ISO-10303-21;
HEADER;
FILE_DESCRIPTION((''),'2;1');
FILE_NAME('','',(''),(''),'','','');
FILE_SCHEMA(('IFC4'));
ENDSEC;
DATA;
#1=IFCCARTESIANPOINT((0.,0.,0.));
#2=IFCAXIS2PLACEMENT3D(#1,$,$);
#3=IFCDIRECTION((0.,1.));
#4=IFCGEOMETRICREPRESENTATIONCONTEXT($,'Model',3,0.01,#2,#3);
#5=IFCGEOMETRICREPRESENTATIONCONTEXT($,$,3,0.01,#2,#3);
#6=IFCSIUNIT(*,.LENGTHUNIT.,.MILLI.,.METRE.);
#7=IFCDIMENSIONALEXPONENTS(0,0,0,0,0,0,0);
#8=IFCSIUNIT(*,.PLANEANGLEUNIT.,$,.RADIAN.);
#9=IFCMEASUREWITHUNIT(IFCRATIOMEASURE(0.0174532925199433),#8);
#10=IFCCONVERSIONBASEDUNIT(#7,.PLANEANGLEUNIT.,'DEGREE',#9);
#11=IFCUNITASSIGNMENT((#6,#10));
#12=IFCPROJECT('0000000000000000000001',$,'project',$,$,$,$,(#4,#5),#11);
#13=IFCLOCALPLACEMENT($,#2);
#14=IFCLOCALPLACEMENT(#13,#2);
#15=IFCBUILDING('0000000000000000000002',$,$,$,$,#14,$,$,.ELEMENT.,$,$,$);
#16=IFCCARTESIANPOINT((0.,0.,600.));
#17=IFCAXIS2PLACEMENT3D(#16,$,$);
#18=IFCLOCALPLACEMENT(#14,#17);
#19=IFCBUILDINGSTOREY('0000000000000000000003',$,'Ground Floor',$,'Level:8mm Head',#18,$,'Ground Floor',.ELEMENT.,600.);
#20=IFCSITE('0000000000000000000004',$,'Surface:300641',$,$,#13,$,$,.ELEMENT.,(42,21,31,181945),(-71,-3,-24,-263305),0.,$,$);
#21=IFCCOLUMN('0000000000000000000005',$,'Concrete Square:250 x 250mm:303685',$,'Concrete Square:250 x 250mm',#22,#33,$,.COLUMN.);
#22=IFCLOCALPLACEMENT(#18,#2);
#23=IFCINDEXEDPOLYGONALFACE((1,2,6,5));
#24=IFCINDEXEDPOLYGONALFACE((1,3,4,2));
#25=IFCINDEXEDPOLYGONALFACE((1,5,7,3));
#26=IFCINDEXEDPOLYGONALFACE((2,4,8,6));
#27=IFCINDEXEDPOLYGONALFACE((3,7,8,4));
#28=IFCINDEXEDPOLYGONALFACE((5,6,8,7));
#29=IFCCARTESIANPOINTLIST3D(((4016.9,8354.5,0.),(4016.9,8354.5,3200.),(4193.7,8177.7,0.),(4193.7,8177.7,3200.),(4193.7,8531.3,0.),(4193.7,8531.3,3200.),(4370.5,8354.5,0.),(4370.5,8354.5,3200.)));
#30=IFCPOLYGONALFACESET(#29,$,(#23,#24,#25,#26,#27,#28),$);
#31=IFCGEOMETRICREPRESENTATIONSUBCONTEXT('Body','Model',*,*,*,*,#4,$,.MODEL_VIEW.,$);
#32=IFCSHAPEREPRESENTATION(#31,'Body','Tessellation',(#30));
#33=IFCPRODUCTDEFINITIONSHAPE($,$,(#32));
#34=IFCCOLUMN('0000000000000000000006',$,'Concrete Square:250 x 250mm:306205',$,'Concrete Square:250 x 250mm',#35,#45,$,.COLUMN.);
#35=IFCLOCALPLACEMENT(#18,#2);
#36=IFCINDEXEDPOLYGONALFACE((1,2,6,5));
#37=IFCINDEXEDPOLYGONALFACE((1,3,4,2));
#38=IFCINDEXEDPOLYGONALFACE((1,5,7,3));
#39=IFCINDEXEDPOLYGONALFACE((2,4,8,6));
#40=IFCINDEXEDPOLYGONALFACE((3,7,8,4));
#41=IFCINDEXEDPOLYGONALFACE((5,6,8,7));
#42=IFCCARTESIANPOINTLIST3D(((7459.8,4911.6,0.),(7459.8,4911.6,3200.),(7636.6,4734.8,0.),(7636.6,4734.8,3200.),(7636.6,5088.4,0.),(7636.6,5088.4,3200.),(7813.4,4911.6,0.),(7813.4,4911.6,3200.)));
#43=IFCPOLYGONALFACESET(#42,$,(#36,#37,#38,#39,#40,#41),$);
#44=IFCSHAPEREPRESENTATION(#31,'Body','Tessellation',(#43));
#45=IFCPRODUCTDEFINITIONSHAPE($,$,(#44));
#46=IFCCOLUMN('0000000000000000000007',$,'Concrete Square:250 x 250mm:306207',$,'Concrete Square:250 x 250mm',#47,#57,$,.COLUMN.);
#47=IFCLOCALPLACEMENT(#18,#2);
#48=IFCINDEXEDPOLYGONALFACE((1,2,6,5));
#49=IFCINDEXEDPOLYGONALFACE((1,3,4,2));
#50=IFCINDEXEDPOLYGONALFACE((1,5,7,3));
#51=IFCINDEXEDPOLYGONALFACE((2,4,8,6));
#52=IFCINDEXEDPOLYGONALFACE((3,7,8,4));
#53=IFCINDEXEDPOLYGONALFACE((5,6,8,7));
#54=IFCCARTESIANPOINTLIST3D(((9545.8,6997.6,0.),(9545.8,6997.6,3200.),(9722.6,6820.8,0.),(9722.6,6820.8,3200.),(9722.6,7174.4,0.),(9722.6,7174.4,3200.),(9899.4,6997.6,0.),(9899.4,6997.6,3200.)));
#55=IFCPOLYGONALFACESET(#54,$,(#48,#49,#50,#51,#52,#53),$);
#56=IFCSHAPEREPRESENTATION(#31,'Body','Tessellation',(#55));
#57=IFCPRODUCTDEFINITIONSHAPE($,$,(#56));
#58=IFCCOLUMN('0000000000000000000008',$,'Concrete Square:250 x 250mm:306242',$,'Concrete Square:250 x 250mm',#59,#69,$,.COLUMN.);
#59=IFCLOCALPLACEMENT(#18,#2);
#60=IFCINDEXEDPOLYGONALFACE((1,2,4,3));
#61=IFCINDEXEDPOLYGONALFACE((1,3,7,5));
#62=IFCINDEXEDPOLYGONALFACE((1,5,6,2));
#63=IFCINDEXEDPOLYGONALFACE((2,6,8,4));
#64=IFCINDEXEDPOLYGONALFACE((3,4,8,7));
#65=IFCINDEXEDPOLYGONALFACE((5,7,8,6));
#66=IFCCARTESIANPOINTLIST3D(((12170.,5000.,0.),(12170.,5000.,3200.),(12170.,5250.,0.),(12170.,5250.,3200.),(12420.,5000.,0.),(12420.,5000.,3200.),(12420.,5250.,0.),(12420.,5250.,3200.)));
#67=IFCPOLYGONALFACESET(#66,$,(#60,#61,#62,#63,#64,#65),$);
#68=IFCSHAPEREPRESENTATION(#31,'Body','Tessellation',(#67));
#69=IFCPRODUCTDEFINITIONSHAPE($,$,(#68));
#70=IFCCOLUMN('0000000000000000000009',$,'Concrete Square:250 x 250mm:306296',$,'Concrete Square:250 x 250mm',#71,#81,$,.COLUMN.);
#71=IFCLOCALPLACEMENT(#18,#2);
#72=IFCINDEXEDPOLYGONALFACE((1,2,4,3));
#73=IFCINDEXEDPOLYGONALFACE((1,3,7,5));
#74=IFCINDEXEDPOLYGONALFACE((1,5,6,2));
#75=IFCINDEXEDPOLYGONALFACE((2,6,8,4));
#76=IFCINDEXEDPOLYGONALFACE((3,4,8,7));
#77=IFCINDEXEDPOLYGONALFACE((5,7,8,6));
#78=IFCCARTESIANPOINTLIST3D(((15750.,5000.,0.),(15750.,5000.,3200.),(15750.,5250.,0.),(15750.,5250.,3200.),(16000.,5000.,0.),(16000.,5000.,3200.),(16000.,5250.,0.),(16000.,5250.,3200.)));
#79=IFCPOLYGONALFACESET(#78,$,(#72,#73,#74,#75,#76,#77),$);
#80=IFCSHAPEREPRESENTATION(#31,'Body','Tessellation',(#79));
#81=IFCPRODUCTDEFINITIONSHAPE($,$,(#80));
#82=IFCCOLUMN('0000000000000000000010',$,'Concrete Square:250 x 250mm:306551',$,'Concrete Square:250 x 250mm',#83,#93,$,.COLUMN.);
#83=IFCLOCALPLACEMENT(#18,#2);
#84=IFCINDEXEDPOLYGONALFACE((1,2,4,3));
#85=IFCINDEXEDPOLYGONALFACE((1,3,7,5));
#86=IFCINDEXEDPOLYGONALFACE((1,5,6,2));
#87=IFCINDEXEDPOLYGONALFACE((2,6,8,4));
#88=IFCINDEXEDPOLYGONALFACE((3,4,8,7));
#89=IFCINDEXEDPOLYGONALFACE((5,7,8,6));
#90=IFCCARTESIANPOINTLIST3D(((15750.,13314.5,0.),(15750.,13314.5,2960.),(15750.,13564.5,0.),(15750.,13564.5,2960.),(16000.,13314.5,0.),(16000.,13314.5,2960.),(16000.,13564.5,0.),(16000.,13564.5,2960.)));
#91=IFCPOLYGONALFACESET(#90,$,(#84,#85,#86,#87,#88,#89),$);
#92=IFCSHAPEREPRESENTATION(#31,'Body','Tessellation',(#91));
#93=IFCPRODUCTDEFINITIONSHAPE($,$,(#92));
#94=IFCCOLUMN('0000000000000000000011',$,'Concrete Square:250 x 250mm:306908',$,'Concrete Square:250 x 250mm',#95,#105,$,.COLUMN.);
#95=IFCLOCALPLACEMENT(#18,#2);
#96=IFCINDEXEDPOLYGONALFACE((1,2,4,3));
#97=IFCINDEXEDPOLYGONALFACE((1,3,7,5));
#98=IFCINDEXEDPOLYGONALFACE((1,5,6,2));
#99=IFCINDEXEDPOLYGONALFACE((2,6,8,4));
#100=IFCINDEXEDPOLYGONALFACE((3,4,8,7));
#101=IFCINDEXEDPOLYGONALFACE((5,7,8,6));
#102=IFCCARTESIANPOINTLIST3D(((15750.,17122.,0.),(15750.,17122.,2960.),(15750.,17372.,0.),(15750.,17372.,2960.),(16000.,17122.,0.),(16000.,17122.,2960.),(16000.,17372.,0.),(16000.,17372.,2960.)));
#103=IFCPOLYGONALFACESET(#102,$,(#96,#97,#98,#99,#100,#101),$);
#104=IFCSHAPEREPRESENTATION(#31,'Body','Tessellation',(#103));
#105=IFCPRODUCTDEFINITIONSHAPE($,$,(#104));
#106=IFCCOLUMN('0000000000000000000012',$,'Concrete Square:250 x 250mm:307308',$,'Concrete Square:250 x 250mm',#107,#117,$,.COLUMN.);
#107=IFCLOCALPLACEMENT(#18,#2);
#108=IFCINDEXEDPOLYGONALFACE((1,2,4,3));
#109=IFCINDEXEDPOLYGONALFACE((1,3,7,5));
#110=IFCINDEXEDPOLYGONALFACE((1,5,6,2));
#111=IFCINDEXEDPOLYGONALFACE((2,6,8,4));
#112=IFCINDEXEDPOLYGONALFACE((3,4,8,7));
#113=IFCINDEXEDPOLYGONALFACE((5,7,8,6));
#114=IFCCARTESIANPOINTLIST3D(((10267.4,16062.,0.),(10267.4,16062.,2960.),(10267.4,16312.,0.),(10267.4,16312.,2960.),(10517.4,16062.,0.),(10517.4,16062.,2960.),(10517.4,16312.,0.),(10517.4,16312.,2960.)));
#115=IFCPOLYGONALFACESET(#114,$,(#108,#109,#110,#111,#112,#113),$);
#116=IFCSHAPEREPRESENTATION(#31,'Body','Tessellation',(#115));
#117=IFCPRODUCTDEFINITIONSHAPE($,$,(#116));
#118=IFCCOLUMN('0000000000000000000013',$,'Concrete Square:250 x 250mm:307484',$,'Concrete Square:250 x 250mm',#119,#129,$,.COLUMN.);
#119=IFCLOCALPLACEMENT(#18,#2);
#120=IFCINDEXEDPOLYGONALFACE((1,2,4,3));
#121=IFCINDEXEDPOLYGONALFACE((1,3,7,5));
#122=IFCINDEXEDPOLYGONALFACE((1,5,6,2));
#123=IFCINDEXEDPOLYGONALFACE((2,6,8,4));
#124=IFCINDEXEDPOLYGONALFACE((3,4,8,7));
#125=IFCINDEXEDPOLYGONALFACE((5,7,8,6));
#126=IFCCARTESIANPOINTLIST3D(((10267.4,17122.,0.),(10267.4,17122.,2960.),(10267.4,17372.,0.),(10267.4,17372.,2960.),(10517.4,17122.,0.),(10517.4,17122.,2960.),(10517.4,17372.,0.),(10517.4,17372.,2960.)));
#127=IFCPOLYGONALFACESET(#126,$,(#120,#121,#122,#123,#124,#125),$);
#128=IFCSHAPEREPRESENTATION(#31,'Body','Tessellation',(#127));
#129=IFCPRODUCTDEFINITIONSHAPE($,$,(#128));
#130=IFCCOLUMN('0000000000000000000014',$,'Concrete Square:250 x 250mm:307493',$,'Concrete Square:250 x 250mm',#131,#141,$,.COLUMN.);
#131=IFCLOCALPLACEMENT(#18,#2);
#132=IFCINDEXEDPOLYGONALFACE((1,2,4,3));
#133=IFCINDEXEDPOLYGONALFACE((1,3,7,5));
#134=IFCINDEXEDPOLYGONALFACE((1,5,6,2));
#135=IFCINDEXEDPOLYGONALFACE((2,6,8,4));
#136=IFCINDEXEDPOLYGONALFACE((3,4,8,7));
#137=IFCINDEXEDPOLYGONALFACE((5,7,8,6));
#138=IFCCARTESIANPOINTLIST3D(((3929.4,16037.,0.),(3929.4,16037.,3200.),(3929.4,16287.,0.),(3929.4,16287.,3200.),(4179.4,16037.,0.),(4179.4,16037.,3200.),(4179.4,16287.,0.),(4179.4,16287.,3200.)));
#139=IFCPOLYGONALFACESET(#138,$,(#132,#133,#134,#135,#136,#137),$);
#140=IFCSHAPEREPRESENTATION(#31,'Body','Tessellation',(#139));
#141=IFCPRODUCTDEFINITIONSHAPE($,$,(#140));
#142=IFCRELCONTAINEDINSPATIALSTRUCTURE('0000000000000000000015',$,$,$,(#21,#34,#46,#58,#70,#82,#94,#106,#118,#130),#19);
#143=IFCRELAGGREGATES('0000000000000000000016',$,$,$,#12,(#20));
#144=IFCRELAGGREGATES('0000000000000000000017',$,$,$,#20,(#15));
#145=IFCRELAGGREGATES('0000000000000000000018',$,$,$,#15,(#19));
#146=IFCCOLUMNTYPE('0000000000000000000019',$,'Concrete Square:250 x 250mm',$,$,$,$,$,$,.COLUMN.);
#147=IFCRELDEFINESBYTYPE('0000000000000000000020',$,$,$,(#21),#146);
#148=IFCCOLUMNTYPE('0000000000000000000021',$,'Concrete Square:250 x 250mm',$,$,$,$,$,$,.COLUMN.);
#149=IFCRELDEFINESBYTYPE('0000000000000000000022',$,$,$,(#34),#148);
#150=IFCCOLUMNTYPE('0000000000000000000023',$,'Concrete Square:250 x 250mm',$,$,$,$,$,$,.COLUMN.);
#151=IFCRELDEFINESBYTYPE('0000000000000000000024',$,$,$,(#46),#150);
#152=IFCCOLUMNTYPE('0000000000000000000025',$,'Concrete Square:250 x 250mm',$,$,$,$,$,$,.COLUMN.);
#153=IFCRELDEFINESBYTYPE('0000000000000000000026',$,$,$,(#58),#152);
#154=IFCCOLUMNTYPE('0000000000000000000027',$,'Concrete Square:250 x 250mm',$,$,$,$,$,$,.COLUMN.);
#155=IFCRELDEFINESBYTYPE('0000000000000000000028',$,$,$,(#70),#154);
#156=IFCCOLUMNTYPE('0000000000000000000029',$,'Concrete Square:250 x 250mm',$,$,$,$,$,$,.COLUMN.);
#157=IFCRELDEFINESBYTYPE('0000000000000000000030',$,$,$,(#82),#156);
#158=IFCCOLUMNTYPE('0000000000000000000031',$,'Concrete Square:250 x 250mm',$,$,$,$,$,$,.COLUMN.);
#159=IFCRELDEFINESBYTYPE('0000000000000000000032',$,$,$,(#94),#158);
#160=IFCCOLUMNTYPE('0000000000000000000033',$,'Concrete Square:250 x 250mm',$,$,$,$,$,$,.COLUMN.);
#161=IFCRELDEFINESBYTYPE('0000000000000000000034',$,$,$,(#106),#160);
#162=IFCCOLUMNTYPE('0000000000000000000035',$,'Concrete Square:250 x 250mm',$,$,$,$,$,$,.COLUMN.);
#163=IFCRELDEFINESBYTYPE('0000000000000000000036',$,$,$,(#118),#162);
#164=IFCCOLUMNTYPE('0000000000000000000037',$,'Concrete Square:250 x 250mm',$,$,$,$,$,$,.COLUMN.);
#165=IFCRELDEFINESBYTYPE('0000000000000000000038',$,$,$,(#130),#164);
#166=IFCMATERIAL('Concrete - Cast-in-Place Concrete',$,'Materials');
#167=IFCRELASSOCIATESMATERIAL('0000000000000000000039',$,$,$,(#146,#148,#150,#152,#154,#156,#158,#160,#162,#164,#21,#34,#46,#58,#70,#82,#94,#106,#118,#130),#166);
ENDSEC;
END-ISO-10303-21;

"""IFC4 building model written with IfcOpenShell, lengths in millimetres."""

from ifc_helpers import new_model, entity, si_unit, converted_unit, direction, frame, frame_2d, origin, origin_2d_with_axis, place, context, subcontext, project, spatial, rectangle, extrude, source, transform, mapped, material, material_profile, profile_set, profile_usage, type_object, type_shapes, element, save


model = new_model("IFC4")

# Units and contexts
model_context = context("Model", 3, precision=0.01, world=origin(), true_north=direction((0.0, 1.0)))
context_of_model = context(None, 3, precision=0.01, world=origin(), true_north=direction((0.0, 1.0)))
body_context = subcontext(model_context, "Body", "Model", "MODEL_VIEW")
ifc_project = project(units=[si_unit("LENGTHUNIT", "METRE", prefix="MILLI"), converted_unit("PLANEANGLEUNIT", "DEGREE", entity("IfcRatioMeasure", 0.0174532925199433), si_unit("PLANEANGLEUNIT", "RADIAN"), dimensions=[0, 0, 0, 0, 0, 0, 0])], contexts=[model_context, context_of_model])

# Site, building, storey
site_placement = place(None, origin())
site = spatial("IfcSite", under=ifc_project, at=site_placement, Name="Surface:300641", CompositionType="ELEMENT", RefLatitude=(42, 21, 31, 181945), RefLongitude=(-71, -3, -24, -263305), RefElevation=0.0)
building_placement = place(site_placement, origin())
building = spatial("IfcBuilding", under=site, at=building_placement, CompositionType="ELEMENT")
storey_placement = place(building_placement, frame((0.0, 0.0, 600.0)))
storey = spatial("IfcBuildingStorey", under=building, at=storey_placement, Name="Ground Floor", ObjectType="Level:8mm Head", LongName="Ground Floor", CompositionType="ELEMENT", Elevation=600.0)

# Columns
ifc_material_1 = material(Name="Concrete - Cast-in-Place Concrete", Category="Materials")
ifc_material_profile_1 = material_profile(ifc_material_1, rectangle(XDim=250.0, YDim=250.0, at=frame_2d((0.0, 0.0), x_axis=(1.0, 0.0))), Name="250 x 250mm")
ifc_profile_set_1 = profile_set([ifc_material_profile_1], Name="250 x 250mm")
ifc_profile_usage_1 = profile_usage(ifc_profile_set_1)
column_type_1 = type_object("IfcColumnType", Name="Concrete Square:250 x 250mm", PredefinedType="COLUMN", material=ifc_profile_set_1)
shared_shape_1 = source(origin(), body_context, "Body", "SweptSolid", [
    extrude(rectangle(XDim=250.0, YDim=250.0, at=frame_2d((0.0, 0.0), x_axis=(1.0, 0.0))), frame((4193.7, 8354.5, 600.0), z_axis=(0.0, 0.0, 1.0), x_axis=(-0.707107, 0.707107, 0.0)), (0.0, 0.0, 1.0), 3200.0),
])
type_shapes(column_type_1, [shared_shape_1])
column_1_placement = place(storey_placement, frame((0.0, 0.0, -600.0)))
element("IfcColumn", 1, at=column_1_placement, inside=storey, type_object=column_type_1, material=ifc_profile_usage_1, Name="Concrete Square:250 x 250mm:303685", ObjectType="Concrete Square:250 x 250mm", PredefinedType="COLUMN", context=body_context, shape_type="MappedRepresentation", body=[
    mapped(shared_shape_1, transform((0.0, 0.0, 0.0), scale=1.0)),
])
ifc_profile_usage_2 = profile_usage(ifc_profile_set_1)
column_type_2 = type_object("IfcColumnType", Name="Concrete Square:250 x 250mm", PredefinedType="COLUMN", material=ifc_profile_set_1)
shared_shape_2 = source(origin(), body_context, "Body", "SweptSolid", [
    extrude(rectangle(XDim=250.0, YDim=250.0, at=frame_2d((0.0, 0.0), x_axis=(1.0, 0.0))), frame((7636.6, 4911.6, 600.0), z_axis=(0.0, 0.0, 1.0), x_axis=(-0.707107, 0.707107, 0.0)), (0.0, 0.0, 1.0), 3200.0),
])
type_shapes(column_type_2, [shared_shape_2])
column_2_placement = place(storey_placement, frame((0.0, 0.0, -600.0)))
element("IfcColumn", 2, at=column_2_placement, inside=storey, type_object=column_type_2, material=ifc_profile_usage_2, Name="Concrete Square:250 x 250mm:306205", ObjectType="Concrete Square:250 x 250mm", PredefinedType="COLUMN", context=body_context, shape_type="MappedRepresentation", body=[
    mapped(shared_shape_2, transform((0.0, 0.0, 0.0), scale=1.0)),
])
ifc_profile_usage_3 = profile_usage(ifc_profile_set_1)
column_type_3 = type_object("IfcColumnType", Name="Concrete Square:250 x 250mm", PredefinedType="COLUMN", material=ifc_profile_set_1)
shared_shape_3 = source(origin(), body_context, "Body", "SweptSolid", [
    extrude(rectangle(XDim=250.0, YDim=250.0, at=frame_2d((0.0, 0.0), x_axis=(1.0, 0.0))), frame((9722.6, 6997.6, 600.0), z_axis=(0.0, 0.0, 1.0), x_axis=(-0.707107, 0.707107, 0.0)), (0.0, 0.0, 1.0), 3200.0),
])
type_shapes(column_type_3, [shared_shape_3])
column_3_placement = place(storey_placement, frame((0.0, 0.0, -600.0)))
element("IfcColumn", 3, at=column_3_placement, inside=storey, type_object=column_type_3, material=ifc_profile_usage_3, Name="Concrete Square:250 x 250mm:306207", ObjectType="Concrete Square:250 x 250mm", PredefinedType="COLUMN", context=body_context, shape_type="MappedRepresentation", body=[
    mapped(shared_shape_3, transform((0.0, 0.0, 0.0), scale=1.0)),
])
ifc_profile_usage_4 = profile_usage(ifc_profile_set_1)
column_type_4 = type_object("IfcColumnType", Name="Concrete Square:250 x 250mm", PredefinedType="COLUMN", material=ifc_profile_set_1)
shared_shape_4 = source(origin(), body_context, "Body", "SweptSolid", [
    extrude(rectangle(XDim=250.0, YDim=250.0, at=origin_2d_with_axis()), frame((12295.0, 5125.0, 600.0), z_axis=(0.0, 0.0, 1.0), x_axis=(0.0, -1.0, 0.0)), (0.0, 0.0, 1.0), 3200.0),
])
type_shapes(column_type_4, [shared_shape_4])
column_4_placement = place(storey_placement, frame((0.0, 0.0, -600.0)))
element("IfcColumn", 4, at=column_4_placement, inside=storey, type_object=column_type_4, material=ifc_profile_usage_4, Name="Concrete Square:250 x 250mm:306242", ObjectType="Concrete Square:250 x 250mm", PredefinedType="COLUMN", context=body_context, shape_type="MappedRepresentation", body=[
    mapped(shared_shape_4, transform((0.0, 0.0, 0.0), scale=1.0)),
])
ifc_profile_usage_5 = profile_usage(ifc_profile_set_1)
column_type_5 = type_object("IfcColumnType", Name="Concrete Square:250 x 250mm", PredefinedType="COLUMN", material=ifc_profile_set_1)
shared_shape_5 = source(origin(), body_context, "Body", "SweptSolid", [
    extrude(rectangle(XDim=250.0, YDim=250.0, at=origin_2d_with_axis()), frame((15875.0, 5125.0, 600.0), z_axis=(0.0, 0.0, 1.0), x_axis=(0.0, -1.0, 0.0)), (0.0, 0.0, 1.0), 3200.0),
])
type_shapes(column_type_5, [shared_shape_5])
column_5_placement = place(storey_placement, frame((0.0, 0.0, -600.0)))
element("IfcColumn", 5, at=column_5_placement, inside=storey, type_object=column_type_5, material=ifc_profile_usage_5, Name="Concrete Square:250 x 250mm:306296", ObjectType="Concrete Square:250 x 250mm", PredefinedType="COLUMN", context=body_context, shape_type="MappedRepresentation", body=[
    mapped(shared_shape_5, transform((0.0, 0.0, 0.0), scale=1.0)),
])
ifc_profile_usage_6 = profile_usage(ifc_profile_set_1)
column_type_6 = type_object("IfcColumnType", Name="Concrete Square:250 x 250mm", PredefinedType="COLUMN", material=ifc_profile_set_1)
shared_shape_6 = source(origin(), body_context, "Body", "SweptSolid", [
    extrude(rectangle(XDim=250.0, YDim=250.0, at=frame_2d((0.0, 0.0), x_axis=(1.0, 0.0))), frame((15875.0, 13439.5, 600.0), z_axis=(0.0, 0.0, 1.0), x_axis=(0.0, -1.0, 0.0)), (0.0, 0.0, 1.0), 2960.0),
])
type_shapes(column_type_6, [shared_shape_6])
column_6_placement = place(storey_placement, frame((0.0, 0.0, -600.0)))
element("IfcColumn", 6, at=column_6_placement, inside=storey, type_object=column_type_6, material=ifc_profile_usage_6, Name="Concrete Square:250 x 250mm:306551", ObjectType="Concrete Square:250 x 250mm", PredefinedType="COLUMN", context=body_context, shape_type="MappedRepresentation", body=[
    mapped(shared_shape_6, transform((0.0, 0.0, 0.0), scale=1.0)),
])
ifc_profile_usage_7 = profile_usage(ifc_profile_set_1)
column_type_7 = type_object("IfcColumnType", Name="Concrete Square:250 x 250mm", PredefinedType="COLUMN", material=ifc_profile_set_1)
shared_shape_7 = source(origin(), body_context, "Body", "SweptSolid", [
    extrude(rectangle(XDim=250.0, YDim=250.0, at=origin_2d_with_axis()), frame((15875.0, 17247.0, 600.0), z_axis=(0.0, 0.0, 1.0), x_axis=(0.0, -1.0, 0.0)), (0.0, 0.0, 1.0), 2960.0),
])
type_shapes(column_type_7, [shared_shape_7])
column_7_placement = place(storey_placement, frame((0.0, 0.0, -600.0)))
element("IfcColumn", 7, at=column_7_placement, inside=storey, type_object=column_type_7, material=ifc_profile_usage_7, Name="Concrete Square:250 x 250mm:306908", ObjectType="Concrete Square:250 x 250mm", PredefinedType="COLUMN", context=body_context, shape_type="MappedRepresentation", body=[
    mapped(shared_shape_7, transform((0.0, 0.0, 0.0), scale=1.0)),
])
ifc_profile_usage_8 = profile_usage(ifc_profile_set_1)
column_type_8 = type_object("IfcColumnType", Name="Concrete Square:250 x 250mm", PredefinedType="COLUMN", material=ifc_profile_set_1)
shared_shape_8 = source(origin(), body_context, "Body", "SweptSolid", [
    extrude(rectangle(XDim=250.0, YDim=250.0, at=frame_2d((0.0, 0.0), x_axis=(1.0, 0.0))), frame((10392.4, 16187.0, 600.0), z_axis=(0.0, 0.0, 1.0), x_axis=(0.0, -1.0, 0.0)), (0.0, 0.0, 1.0), 2960.0),
])
type_shapes(column_type_8, [shared_shape_8])
column_8_placement = place(storey_placement, frame((0.0, 0.0, -600.0)))
element("IfcColumn", 8, at=column_8_placement, inside=storey, type_object=column_type_8, material=ifc_profile_usage_8, Name="Concrete Square:250 x 250mm:307308", ObjectType="Concrete Square:250 x 250mm", PredefinedType="COLUMN", context=body_context, shape_type="MappedRepresentation", body=[
    mapped(shared_shape_8, transform((0.0, 0.0, 0.0), scale=1.0)),
])
ifc_profile_usage_9 = profile_usage(ifc_profile_set_1)
column_type_9 = type_object("IfcColumnType", Name="Concrete Square:250 x 250mm", PredefinedType="COLUMN", material=ifc_profile_set_1)
shared_shape_9 = source(origin(), body_context, "Body", "SweptSolid", [
    extrude(rectangle(XDim=250.0, YDim=250.0, at=origin_2d_with_axis()), frame((10392.4, 17247.0, 600.0), z_axis=(0.0, 0.0, 1.0), x_axis=(0.0, -1.0, 0.0)), (0.0, 0.0, 1.0), 2960.0),
])
type_shapes(column_type_9, [shared_shape_9])
column_9_placement = place(storey_placement, frame((0.0, 0.0, -600.0)))
element("IfcColumn", 9, at=column_9_placement, inside=storey, type_object=column_type_9, material=ifc_profile_usage_9, Name="Concrete Square:250 x 250mm:307484", ObjectType="Concrete Square:250 x 250mm", PredefinedType="COLUMN", context=body_context, shape_type="MappedRepresentation", body=[
    mapped(shared_shape_9, transform((0.0, 0.0, 0.0), scale=1.0)),
])
ifc_profile_usage_10 = profile_usage(ifc_profile_set_1)
column_type_10 = type_object("IfcColumnType", Name="Concrete Square:250 x 250mm", PredefinedType="COLUMN", material=ifc_profile_set_1)
shared_shape_10 = source(origin(), body_context, "Body", "SweptSolid", [
    extrude(rectangle(XDim=250.0, YDim=250.0, at=frame_2d((0.0, 0.0), x_axis=(1.0, 0.0))), frame((4054.4, 16162.0, 600.0), z_axis=(0.0, 0.0, 1.0), x_axis=(0.0, -1.0, 0.0)), (0.0, 0.0, 1.0), 3200.0),
])
type_shapes(column_type_10, [shared_shape_10])
column_10_placement = place(storey_placement, frame((0.0, 0.0, -600.0)))
element("IfcColumn", 10, at=column_10_placement, inside=storey, type_object=column_type_10, material=ifc_profile_usage_10, Name="Concrete Square:250 x 250mm:307493", ObjectType="Concrete Square:250 x 250mm", PredefinedType="COLUMN", context=body_context, shape_type="MappedRepresentation", body=[
    mapped(shared_shape_10, transform((0.0, 0.0, 0.0), scale=1.0)),
])

save(model, "model.ifc")
